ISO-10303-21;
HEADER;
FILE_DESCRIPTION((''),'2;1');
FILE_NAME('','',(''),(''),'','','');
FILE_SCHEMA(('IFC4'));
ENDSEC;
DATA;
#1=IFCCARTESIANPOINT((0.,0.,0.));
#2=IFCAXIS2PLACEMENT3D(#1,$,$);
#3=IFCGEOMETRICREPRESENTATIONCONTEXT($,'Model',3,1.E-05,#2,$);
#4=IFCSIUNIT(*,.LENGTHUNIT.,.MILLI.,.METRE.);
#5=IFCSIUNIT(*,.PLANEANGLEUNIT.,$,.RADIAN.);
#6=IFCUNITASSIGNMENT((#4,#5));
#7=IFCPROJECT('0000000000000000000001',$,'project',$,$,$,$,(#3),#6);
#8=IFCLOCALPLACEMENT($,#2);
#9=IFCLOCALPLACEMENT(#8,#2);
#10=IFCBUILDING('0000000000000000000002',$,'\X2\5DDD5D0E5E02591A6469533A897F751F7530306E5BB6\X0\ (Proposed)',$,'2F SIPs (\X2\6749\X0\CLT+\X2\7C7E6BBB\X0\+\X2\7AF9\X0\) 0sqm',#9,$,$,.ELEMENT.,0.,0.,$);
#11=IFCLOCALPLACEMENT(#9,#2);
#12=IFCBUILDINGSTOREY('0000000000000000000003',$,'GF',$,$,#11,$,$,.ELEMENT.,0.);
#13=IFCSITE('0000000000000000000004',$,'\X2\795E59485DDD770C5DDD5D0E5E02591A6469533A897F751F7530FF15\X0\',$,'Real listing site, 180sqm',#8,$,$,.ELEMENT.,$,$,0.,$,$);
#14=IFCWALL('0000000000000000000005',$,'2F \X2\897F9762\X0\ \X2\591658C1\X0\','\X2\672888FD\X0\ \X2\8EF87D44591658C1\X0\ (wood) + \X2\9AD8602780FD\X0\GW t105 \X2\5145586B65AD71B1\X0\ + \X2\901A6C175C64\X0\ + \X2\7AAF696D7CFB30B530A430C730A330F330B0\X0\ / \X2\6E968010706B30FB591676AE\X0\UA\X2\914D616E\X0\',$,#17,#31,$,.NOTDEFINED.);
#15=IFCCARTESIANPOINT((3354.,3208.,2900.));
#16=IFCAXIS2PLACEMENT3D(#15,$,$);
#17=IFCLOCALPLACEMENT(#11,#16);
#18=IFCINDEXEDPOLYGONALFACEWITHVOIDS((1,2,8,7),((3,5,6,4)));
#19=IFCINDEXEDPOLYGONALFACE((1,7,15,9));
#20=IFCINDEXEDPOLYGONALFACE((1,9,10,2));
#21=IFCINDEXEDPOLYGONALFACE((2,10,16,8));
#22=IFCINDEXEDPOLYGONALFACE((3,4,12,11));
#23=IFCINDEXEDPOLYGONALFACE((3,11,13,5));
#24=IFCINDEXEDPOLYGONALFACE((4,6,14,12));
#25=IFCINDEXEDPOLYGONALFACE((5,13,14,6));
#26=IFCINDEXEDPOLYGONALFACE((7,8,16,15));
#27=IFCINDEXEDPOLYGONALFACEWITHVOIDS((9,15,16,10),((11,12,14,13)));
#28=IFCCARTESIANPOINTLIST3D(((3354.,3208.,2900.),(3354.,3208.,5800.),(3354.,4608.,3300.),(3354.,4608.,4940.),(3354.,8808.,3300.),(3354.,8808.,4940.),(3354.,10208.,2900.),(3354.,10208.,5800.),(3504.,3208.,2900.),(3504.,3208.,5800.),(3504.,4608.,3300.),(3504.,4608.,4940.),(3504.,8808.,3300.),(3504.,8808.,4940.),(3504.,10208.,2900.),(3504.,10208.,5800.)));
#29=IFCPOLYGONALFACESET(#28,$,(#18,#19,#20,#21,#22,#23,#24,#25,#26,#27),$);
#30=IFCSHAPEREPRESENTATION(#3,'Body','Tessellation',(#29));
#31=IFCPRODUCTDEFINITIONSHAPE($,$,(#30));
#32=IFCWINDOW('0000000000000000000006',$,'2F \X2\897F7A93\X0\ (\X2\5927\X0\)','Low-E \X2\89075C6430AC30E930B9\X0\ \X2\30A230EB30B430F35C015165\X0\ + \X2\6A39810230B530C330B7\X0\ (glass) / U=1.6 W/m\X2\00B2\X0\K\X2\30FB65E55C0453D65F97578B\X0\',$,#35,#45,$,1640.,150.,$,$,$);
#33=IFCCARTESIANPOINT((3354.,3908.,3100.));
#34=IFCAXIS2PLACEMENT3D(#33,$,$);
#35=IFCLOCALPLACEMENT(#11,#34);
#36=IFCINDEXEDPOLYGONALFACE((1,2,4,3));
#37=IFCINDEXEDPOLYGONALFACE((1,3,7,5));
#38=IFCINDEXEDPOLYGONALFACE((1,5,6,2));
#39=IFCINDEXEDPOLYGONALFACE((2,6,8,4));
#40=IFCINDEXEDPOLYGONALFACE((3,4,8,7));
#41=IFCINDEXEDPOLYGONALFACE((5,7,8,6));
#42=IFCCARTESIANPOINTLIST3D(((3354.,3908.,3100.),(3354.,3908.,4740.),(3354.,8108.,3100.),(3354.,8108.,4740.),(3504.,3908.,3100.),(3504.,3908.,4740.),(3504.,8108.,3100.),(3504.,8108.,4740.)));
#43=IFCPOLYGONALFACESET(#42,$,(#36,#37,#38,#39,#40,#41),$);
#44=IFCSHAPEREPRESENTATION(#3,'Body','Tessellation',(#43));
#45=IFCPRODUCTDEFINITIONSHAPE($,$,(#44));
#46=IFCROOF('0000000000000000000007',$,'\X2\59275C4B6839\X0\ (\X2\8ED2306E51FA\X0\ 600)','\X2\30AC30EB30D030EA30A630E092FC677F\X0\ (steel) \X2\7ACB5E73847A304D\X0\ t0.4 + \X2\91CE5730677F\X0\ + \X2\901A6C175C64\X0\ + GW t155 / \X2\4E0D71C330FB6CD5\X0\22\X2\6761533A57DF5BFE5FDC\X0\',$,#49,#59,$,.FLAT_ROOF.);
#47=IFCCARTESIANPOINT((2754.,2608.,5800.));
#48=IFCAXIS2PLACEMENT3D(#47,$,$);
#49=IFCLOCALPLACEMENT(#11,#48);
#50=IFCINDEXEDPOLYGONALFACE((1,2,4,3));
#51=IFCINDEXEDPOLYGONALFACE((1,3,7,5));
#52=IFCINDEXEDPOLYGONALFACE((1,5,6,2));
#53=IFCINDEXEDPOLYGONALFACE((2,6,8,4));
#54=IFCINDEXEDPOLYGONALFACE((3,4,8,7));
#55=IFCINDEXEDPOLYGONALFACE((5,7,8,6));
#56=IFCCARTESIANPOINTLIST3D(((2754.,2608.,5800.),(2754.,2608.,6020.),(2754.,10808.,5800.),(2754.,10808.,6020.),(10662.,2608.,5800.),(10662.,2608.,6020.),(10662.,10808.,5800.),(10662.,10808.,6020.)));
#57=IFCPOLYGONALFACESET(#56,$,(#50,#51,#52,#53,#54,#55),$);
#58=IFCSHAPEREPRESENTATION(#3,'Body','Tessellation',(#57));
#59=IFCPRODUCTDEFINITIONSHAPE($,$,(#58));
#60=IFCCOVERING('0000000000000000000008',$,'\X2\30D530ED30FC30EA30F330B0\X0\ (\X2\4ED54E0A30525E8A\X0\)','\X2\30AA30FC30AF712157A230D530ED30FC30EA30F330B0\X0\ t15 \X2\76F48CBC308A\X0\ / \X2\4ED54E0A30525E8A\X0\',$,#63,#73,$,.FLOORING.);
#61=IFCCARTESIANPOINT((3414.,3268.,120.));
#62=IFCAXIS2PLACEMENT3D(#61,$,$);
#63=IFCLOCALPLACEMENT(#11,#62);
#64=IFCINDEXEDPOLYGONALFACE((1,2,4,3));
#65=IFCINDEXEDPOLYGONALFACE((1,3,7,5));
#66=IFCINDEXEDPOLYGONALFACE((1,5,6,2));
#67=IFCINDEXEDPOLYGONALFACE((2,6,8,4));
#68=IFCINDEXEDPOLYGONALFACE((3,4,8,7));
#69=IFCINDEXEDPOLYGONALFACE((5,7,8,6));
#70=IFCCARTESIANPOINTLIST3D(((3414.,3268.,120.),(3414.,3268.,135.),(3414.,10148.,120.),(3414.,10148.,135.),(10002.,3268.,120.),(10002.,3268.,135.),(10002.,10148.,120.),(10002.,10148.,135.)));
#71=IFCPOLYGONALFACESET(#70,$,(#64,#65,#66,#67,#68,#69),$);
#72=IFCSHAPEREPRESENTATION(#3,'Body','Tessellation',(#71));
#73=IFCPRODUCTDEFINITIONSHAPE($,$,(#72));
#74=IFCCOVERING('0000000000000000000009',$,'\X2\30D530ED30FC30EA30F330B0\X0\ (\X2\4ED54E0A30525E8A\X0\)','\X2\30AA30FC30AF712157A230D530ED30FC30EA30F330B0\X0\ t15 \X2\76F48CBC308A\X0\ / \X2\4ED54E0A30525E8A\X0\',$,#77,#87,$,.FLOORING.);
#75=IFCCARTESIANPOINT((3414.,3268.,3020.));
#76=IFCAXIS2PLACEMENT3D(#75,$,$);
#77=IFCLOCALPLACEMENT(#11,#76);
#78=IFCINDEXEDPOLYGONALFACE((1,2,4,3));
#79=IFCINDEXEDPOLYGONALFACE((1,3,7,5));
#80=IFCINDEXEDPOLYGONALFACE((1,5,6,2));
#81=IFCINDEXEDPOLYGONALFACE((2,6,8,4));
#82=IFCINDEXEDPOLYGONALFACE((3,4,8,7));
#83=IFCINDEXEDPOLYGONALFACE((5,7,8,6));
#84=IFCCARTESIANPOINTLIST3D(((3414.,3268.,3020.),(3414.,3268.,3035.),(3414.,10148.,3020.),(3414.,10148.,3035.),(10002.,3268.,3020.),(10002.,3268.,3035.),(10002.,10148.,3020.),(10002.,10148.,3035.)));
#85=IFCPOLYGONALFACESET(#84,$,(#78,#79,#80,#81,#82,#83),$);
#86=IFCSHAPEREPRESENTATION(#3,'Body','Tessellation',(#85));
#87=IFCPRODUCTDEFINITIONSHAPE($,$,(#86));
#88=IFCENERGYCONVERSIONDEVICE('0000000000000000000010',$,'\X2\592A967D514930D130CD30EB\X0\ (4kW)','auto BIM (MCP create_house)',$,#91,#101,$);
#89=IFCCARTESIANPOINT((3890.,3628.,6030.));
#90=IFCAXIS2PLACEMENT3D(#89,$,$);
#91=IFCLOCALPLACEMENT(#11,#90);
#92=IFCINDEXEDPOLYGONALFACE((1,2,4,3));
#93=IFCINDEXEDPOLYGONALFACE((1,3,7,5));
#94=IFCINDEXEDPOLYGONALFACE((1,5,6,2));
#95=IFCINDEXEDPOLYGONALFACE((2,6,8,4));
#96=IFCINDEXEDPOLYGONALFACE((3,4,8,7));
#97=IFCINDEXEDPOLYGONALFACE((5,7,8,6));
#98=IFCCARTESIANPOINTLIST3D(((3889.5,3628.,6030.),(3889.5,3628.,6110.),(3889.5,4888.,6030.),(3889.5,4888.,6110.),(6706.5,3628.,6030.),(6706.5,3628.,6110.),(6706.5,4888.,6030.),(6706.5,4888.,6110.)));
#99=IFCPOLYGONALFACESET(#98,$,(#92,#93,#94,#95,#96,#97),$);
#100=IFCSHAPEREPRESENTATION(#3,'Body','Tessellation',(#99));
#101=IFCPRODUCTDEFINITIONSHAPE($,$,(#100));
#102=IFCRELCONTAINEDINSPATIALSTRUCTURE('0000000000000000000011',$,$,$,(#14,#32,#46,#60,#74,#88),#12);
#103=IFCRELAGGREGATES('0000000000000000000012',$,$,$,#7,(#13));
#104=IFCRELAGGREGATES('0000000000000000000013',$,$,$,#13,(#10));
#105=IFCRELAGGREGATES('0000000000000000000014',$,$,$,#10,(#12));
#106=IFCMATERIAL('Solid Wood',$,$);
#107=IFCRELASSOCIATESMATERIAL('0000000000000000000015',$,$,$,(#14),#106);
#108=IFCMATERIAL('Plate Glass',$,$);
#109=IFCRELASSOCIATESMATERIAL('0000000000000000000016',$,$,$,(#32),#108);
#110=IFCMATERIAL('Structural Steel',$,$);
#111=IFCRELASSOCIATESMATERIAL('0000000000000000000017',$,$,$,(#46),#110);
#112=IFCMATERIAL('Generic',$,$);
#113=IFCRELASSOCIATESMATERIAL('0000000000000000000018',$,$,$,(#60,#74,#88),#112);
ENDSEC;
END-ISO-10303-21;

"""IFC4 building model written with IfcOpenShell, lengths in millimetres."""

from ifc_helpers import new_model, si_unit, frame, frame_2d, origin, place, context, project, spatial, rectangle, extrude, material, element, fill, save


model = new_model("IFC4")

# Units and contexts
model_context = context("Model", 3, precision=1e-05, world=origin())
ifc_project = project(units=[si_unit("LENGTHUNIT", "METRE", prefix="MILLI"), si_unit("PLANEANGLEUNIT", "RADIAN")], contexts=[model_context])

# Site, building, storey
site_placement = place(None, origin())
site = spatial("IfcSite", under=ifc_project, at=site_placement, Name="神奈川県川崎市多摩区西生田５", ObjectType="Real listing site, 180sqm", CompositionType="ELEMENT", RefElevation=0.0)
building_placement = place(site_placement, origin())
building = spatial("IfcBuilding", under=site, at=building_placement, Name="川崎市多摩区西生田の家 (Proposed)", ObjectType="2F SIPs (杉CLT+籾殻+竹) 0sqm", CompositionType="ELEMENT", ElevationOfRefHeight=0.0, ElevationOfTerrain=0.0)
storey_placement = place(building_placement, origin())
storey = spatial("IfcBuildingStorey", under=building, at=storey_placement, Name="GF", CompositionType="ELEMENT", Elevation=0.0)

# Shared definitions
ifc_material_1 = material(Name="Solid Wood")

# Shared definitions
ifc_material_2 = material(Name="Plate Glass")

# Wall, opening, window
wall_1_placement = place(storey_placement, frame((3354.0, 3208.0, 2900.0)))
wall_1 = element("IfcWall", 1, at=wall_1_placement, inside=storey, material=ifc_material_1, Name="2F 西面 外壁", Description="木製 軸組外壁 (wood) + 高性能GW t105 充填断熱 + 通気層 + 窯業系サイディング / 準耐火・外皮UA配慮", PredefinedType="NOTDEFINED", context=model_context, shape_type="SweptSolid", body=[
    extrude(rectangle(XDim=150.0, YDim=7000.0, at=frame_2d((75.0, 3500.0))), frame((3354.0, 3208.0, 2900.0)), (0.0, 0.0, 1.0), 2900.0),
])
opening_1_placement = place(storey_placement, frame((3354.0, 3908.0, 3100.0)))
opening_1 = element("IfcOpeningElement", 2, at=opening_1_placement, cuts=wall_1, PredefinedType="NOTDEFINED", context=model_context, shape_type="SweptSolid", body=[
    extrude(rectangle(XDim=150.0, YDim=4200.0, at=frame_2d((75.0, 2100.0))), frame((3354.0, 3908.0, 3100.0)), (0.0, 0.0, 1.0), 1640.0),
])
window_1_placement = place(storey_placement, frame((3354.0, 3908.0, 3100.0)))
window_1 = element("IfcWindow", 3, at=window_1_placement, inside=storey, material=ifc_material_2, Name="2F 西窓 (大)", Description="Low-E 複層ガラス アルゴン封入 + 樹脂サッシ (glass) / U=1.6 W/m²K・日射取得型", OverallHeight=1640.0, OverallWidth=150.0, context=model_context, shape_type="SweptSolid", body=[
    extrude(rectangle(XDim=150.0, YDim=4200.0, at=frame_2d((75.0, 2100.0))), frame((3354.0, 3908.0, 3100.0)), (0.0, 0.0, 1.0), 1640.0),
])
fill(opening_1, window_1)

# Roof
ifc_material_3 = material(Name="Structural Steel")
roof_placement = place(storey_placement, frame((2754.0, 2608.0, 5800.0)))
element("IfcRoof", 4, at=roof_placement, inside=storey, material=ifc_material_3, Name="大屋根 (軒の出 600)", Description="ガルバリウム鋼板 (steel) 立平葺き t0.4 + 野地板 + 通気層 + GW t155 / 不燃・法22条区域対応", PredefinedType="FLAT_ROOF", context=model_context, shape_type="SweptSolid", body=[
    extrude(rectangle(XDim=7908.0, YDim=8200.0, at=frame_2d((3954.0, 4100.0))), frame((2754.0, 2608.0, 5800.0)), (0.0, 0.0, 1.0), 220.0),
])

# Coverings
ifc_material_4 = material(Name="Generic")
covering_1_placement = place(storey_placement, frame((3414.0, 3268.0, 120.0)))
element("IfcCovering", 5, at=covering_1_placement, inside=storey, material=ifc_material_4, Name="フローリング (仕上げ床)", Description="オーク無垢フローリング t15 直貼り / 仕上げ床", PredefinedType="FLOORING", context=model_context, shape_type="SweptSolid", body=[
    extrude(rectangle(XDim=6588.0, YDim=6880.0, at=frame_2d((3294.0, 3440.0))), frame((3414.0, 3268.0, 120.0)), (0.0, 0.0, 1.0), 15.0),
])
covering_2_placement = place(storey_placement, frame((3414.0, 3268.0, 3020.0)))
element("IfcCovering", 6, at=covering_2_placement, inside=storey, material=ifc_material_4, Name="フローリング (仕上げ床)", Description="オーク無垢フローリング t15 直貼り / 仕上げ床", PredefinedType="FLOORING", context=model_context, shape_type="SweptSolid", body=[
    extrude(rectangle(XDim=6588.0, YDim=6880.0, at=frame_2d((3294.0, 3440.0))), frame((3414.0, 3268.0, 3020.0)), (0.0, 0.0, 1.0), 15.0),
])

# Energy conversion device
energy_conversion_device_placement = place(storey_placement, frame((3890.0, 3628.0, 6030.0)))
element("IfcEnergyConversionDevice", 7, at=energy_conversion_device_placement, inside=storey, material=ifc_material_4, Name="太陽光パネル (4kW)", Description="auto BIM (MCP create_house)", context=model_context, shape_type="SweptSolid", body=[
    extrude(rectangle(XDim=2817.0, YDim=1260.0, at=frame_2d((1408.0, 630.0))), frame((3890.0, 3628.0, 6030.0)), (0.0, 0.0, 1.0), 80.0),
])

save(model, "model.ifc")
